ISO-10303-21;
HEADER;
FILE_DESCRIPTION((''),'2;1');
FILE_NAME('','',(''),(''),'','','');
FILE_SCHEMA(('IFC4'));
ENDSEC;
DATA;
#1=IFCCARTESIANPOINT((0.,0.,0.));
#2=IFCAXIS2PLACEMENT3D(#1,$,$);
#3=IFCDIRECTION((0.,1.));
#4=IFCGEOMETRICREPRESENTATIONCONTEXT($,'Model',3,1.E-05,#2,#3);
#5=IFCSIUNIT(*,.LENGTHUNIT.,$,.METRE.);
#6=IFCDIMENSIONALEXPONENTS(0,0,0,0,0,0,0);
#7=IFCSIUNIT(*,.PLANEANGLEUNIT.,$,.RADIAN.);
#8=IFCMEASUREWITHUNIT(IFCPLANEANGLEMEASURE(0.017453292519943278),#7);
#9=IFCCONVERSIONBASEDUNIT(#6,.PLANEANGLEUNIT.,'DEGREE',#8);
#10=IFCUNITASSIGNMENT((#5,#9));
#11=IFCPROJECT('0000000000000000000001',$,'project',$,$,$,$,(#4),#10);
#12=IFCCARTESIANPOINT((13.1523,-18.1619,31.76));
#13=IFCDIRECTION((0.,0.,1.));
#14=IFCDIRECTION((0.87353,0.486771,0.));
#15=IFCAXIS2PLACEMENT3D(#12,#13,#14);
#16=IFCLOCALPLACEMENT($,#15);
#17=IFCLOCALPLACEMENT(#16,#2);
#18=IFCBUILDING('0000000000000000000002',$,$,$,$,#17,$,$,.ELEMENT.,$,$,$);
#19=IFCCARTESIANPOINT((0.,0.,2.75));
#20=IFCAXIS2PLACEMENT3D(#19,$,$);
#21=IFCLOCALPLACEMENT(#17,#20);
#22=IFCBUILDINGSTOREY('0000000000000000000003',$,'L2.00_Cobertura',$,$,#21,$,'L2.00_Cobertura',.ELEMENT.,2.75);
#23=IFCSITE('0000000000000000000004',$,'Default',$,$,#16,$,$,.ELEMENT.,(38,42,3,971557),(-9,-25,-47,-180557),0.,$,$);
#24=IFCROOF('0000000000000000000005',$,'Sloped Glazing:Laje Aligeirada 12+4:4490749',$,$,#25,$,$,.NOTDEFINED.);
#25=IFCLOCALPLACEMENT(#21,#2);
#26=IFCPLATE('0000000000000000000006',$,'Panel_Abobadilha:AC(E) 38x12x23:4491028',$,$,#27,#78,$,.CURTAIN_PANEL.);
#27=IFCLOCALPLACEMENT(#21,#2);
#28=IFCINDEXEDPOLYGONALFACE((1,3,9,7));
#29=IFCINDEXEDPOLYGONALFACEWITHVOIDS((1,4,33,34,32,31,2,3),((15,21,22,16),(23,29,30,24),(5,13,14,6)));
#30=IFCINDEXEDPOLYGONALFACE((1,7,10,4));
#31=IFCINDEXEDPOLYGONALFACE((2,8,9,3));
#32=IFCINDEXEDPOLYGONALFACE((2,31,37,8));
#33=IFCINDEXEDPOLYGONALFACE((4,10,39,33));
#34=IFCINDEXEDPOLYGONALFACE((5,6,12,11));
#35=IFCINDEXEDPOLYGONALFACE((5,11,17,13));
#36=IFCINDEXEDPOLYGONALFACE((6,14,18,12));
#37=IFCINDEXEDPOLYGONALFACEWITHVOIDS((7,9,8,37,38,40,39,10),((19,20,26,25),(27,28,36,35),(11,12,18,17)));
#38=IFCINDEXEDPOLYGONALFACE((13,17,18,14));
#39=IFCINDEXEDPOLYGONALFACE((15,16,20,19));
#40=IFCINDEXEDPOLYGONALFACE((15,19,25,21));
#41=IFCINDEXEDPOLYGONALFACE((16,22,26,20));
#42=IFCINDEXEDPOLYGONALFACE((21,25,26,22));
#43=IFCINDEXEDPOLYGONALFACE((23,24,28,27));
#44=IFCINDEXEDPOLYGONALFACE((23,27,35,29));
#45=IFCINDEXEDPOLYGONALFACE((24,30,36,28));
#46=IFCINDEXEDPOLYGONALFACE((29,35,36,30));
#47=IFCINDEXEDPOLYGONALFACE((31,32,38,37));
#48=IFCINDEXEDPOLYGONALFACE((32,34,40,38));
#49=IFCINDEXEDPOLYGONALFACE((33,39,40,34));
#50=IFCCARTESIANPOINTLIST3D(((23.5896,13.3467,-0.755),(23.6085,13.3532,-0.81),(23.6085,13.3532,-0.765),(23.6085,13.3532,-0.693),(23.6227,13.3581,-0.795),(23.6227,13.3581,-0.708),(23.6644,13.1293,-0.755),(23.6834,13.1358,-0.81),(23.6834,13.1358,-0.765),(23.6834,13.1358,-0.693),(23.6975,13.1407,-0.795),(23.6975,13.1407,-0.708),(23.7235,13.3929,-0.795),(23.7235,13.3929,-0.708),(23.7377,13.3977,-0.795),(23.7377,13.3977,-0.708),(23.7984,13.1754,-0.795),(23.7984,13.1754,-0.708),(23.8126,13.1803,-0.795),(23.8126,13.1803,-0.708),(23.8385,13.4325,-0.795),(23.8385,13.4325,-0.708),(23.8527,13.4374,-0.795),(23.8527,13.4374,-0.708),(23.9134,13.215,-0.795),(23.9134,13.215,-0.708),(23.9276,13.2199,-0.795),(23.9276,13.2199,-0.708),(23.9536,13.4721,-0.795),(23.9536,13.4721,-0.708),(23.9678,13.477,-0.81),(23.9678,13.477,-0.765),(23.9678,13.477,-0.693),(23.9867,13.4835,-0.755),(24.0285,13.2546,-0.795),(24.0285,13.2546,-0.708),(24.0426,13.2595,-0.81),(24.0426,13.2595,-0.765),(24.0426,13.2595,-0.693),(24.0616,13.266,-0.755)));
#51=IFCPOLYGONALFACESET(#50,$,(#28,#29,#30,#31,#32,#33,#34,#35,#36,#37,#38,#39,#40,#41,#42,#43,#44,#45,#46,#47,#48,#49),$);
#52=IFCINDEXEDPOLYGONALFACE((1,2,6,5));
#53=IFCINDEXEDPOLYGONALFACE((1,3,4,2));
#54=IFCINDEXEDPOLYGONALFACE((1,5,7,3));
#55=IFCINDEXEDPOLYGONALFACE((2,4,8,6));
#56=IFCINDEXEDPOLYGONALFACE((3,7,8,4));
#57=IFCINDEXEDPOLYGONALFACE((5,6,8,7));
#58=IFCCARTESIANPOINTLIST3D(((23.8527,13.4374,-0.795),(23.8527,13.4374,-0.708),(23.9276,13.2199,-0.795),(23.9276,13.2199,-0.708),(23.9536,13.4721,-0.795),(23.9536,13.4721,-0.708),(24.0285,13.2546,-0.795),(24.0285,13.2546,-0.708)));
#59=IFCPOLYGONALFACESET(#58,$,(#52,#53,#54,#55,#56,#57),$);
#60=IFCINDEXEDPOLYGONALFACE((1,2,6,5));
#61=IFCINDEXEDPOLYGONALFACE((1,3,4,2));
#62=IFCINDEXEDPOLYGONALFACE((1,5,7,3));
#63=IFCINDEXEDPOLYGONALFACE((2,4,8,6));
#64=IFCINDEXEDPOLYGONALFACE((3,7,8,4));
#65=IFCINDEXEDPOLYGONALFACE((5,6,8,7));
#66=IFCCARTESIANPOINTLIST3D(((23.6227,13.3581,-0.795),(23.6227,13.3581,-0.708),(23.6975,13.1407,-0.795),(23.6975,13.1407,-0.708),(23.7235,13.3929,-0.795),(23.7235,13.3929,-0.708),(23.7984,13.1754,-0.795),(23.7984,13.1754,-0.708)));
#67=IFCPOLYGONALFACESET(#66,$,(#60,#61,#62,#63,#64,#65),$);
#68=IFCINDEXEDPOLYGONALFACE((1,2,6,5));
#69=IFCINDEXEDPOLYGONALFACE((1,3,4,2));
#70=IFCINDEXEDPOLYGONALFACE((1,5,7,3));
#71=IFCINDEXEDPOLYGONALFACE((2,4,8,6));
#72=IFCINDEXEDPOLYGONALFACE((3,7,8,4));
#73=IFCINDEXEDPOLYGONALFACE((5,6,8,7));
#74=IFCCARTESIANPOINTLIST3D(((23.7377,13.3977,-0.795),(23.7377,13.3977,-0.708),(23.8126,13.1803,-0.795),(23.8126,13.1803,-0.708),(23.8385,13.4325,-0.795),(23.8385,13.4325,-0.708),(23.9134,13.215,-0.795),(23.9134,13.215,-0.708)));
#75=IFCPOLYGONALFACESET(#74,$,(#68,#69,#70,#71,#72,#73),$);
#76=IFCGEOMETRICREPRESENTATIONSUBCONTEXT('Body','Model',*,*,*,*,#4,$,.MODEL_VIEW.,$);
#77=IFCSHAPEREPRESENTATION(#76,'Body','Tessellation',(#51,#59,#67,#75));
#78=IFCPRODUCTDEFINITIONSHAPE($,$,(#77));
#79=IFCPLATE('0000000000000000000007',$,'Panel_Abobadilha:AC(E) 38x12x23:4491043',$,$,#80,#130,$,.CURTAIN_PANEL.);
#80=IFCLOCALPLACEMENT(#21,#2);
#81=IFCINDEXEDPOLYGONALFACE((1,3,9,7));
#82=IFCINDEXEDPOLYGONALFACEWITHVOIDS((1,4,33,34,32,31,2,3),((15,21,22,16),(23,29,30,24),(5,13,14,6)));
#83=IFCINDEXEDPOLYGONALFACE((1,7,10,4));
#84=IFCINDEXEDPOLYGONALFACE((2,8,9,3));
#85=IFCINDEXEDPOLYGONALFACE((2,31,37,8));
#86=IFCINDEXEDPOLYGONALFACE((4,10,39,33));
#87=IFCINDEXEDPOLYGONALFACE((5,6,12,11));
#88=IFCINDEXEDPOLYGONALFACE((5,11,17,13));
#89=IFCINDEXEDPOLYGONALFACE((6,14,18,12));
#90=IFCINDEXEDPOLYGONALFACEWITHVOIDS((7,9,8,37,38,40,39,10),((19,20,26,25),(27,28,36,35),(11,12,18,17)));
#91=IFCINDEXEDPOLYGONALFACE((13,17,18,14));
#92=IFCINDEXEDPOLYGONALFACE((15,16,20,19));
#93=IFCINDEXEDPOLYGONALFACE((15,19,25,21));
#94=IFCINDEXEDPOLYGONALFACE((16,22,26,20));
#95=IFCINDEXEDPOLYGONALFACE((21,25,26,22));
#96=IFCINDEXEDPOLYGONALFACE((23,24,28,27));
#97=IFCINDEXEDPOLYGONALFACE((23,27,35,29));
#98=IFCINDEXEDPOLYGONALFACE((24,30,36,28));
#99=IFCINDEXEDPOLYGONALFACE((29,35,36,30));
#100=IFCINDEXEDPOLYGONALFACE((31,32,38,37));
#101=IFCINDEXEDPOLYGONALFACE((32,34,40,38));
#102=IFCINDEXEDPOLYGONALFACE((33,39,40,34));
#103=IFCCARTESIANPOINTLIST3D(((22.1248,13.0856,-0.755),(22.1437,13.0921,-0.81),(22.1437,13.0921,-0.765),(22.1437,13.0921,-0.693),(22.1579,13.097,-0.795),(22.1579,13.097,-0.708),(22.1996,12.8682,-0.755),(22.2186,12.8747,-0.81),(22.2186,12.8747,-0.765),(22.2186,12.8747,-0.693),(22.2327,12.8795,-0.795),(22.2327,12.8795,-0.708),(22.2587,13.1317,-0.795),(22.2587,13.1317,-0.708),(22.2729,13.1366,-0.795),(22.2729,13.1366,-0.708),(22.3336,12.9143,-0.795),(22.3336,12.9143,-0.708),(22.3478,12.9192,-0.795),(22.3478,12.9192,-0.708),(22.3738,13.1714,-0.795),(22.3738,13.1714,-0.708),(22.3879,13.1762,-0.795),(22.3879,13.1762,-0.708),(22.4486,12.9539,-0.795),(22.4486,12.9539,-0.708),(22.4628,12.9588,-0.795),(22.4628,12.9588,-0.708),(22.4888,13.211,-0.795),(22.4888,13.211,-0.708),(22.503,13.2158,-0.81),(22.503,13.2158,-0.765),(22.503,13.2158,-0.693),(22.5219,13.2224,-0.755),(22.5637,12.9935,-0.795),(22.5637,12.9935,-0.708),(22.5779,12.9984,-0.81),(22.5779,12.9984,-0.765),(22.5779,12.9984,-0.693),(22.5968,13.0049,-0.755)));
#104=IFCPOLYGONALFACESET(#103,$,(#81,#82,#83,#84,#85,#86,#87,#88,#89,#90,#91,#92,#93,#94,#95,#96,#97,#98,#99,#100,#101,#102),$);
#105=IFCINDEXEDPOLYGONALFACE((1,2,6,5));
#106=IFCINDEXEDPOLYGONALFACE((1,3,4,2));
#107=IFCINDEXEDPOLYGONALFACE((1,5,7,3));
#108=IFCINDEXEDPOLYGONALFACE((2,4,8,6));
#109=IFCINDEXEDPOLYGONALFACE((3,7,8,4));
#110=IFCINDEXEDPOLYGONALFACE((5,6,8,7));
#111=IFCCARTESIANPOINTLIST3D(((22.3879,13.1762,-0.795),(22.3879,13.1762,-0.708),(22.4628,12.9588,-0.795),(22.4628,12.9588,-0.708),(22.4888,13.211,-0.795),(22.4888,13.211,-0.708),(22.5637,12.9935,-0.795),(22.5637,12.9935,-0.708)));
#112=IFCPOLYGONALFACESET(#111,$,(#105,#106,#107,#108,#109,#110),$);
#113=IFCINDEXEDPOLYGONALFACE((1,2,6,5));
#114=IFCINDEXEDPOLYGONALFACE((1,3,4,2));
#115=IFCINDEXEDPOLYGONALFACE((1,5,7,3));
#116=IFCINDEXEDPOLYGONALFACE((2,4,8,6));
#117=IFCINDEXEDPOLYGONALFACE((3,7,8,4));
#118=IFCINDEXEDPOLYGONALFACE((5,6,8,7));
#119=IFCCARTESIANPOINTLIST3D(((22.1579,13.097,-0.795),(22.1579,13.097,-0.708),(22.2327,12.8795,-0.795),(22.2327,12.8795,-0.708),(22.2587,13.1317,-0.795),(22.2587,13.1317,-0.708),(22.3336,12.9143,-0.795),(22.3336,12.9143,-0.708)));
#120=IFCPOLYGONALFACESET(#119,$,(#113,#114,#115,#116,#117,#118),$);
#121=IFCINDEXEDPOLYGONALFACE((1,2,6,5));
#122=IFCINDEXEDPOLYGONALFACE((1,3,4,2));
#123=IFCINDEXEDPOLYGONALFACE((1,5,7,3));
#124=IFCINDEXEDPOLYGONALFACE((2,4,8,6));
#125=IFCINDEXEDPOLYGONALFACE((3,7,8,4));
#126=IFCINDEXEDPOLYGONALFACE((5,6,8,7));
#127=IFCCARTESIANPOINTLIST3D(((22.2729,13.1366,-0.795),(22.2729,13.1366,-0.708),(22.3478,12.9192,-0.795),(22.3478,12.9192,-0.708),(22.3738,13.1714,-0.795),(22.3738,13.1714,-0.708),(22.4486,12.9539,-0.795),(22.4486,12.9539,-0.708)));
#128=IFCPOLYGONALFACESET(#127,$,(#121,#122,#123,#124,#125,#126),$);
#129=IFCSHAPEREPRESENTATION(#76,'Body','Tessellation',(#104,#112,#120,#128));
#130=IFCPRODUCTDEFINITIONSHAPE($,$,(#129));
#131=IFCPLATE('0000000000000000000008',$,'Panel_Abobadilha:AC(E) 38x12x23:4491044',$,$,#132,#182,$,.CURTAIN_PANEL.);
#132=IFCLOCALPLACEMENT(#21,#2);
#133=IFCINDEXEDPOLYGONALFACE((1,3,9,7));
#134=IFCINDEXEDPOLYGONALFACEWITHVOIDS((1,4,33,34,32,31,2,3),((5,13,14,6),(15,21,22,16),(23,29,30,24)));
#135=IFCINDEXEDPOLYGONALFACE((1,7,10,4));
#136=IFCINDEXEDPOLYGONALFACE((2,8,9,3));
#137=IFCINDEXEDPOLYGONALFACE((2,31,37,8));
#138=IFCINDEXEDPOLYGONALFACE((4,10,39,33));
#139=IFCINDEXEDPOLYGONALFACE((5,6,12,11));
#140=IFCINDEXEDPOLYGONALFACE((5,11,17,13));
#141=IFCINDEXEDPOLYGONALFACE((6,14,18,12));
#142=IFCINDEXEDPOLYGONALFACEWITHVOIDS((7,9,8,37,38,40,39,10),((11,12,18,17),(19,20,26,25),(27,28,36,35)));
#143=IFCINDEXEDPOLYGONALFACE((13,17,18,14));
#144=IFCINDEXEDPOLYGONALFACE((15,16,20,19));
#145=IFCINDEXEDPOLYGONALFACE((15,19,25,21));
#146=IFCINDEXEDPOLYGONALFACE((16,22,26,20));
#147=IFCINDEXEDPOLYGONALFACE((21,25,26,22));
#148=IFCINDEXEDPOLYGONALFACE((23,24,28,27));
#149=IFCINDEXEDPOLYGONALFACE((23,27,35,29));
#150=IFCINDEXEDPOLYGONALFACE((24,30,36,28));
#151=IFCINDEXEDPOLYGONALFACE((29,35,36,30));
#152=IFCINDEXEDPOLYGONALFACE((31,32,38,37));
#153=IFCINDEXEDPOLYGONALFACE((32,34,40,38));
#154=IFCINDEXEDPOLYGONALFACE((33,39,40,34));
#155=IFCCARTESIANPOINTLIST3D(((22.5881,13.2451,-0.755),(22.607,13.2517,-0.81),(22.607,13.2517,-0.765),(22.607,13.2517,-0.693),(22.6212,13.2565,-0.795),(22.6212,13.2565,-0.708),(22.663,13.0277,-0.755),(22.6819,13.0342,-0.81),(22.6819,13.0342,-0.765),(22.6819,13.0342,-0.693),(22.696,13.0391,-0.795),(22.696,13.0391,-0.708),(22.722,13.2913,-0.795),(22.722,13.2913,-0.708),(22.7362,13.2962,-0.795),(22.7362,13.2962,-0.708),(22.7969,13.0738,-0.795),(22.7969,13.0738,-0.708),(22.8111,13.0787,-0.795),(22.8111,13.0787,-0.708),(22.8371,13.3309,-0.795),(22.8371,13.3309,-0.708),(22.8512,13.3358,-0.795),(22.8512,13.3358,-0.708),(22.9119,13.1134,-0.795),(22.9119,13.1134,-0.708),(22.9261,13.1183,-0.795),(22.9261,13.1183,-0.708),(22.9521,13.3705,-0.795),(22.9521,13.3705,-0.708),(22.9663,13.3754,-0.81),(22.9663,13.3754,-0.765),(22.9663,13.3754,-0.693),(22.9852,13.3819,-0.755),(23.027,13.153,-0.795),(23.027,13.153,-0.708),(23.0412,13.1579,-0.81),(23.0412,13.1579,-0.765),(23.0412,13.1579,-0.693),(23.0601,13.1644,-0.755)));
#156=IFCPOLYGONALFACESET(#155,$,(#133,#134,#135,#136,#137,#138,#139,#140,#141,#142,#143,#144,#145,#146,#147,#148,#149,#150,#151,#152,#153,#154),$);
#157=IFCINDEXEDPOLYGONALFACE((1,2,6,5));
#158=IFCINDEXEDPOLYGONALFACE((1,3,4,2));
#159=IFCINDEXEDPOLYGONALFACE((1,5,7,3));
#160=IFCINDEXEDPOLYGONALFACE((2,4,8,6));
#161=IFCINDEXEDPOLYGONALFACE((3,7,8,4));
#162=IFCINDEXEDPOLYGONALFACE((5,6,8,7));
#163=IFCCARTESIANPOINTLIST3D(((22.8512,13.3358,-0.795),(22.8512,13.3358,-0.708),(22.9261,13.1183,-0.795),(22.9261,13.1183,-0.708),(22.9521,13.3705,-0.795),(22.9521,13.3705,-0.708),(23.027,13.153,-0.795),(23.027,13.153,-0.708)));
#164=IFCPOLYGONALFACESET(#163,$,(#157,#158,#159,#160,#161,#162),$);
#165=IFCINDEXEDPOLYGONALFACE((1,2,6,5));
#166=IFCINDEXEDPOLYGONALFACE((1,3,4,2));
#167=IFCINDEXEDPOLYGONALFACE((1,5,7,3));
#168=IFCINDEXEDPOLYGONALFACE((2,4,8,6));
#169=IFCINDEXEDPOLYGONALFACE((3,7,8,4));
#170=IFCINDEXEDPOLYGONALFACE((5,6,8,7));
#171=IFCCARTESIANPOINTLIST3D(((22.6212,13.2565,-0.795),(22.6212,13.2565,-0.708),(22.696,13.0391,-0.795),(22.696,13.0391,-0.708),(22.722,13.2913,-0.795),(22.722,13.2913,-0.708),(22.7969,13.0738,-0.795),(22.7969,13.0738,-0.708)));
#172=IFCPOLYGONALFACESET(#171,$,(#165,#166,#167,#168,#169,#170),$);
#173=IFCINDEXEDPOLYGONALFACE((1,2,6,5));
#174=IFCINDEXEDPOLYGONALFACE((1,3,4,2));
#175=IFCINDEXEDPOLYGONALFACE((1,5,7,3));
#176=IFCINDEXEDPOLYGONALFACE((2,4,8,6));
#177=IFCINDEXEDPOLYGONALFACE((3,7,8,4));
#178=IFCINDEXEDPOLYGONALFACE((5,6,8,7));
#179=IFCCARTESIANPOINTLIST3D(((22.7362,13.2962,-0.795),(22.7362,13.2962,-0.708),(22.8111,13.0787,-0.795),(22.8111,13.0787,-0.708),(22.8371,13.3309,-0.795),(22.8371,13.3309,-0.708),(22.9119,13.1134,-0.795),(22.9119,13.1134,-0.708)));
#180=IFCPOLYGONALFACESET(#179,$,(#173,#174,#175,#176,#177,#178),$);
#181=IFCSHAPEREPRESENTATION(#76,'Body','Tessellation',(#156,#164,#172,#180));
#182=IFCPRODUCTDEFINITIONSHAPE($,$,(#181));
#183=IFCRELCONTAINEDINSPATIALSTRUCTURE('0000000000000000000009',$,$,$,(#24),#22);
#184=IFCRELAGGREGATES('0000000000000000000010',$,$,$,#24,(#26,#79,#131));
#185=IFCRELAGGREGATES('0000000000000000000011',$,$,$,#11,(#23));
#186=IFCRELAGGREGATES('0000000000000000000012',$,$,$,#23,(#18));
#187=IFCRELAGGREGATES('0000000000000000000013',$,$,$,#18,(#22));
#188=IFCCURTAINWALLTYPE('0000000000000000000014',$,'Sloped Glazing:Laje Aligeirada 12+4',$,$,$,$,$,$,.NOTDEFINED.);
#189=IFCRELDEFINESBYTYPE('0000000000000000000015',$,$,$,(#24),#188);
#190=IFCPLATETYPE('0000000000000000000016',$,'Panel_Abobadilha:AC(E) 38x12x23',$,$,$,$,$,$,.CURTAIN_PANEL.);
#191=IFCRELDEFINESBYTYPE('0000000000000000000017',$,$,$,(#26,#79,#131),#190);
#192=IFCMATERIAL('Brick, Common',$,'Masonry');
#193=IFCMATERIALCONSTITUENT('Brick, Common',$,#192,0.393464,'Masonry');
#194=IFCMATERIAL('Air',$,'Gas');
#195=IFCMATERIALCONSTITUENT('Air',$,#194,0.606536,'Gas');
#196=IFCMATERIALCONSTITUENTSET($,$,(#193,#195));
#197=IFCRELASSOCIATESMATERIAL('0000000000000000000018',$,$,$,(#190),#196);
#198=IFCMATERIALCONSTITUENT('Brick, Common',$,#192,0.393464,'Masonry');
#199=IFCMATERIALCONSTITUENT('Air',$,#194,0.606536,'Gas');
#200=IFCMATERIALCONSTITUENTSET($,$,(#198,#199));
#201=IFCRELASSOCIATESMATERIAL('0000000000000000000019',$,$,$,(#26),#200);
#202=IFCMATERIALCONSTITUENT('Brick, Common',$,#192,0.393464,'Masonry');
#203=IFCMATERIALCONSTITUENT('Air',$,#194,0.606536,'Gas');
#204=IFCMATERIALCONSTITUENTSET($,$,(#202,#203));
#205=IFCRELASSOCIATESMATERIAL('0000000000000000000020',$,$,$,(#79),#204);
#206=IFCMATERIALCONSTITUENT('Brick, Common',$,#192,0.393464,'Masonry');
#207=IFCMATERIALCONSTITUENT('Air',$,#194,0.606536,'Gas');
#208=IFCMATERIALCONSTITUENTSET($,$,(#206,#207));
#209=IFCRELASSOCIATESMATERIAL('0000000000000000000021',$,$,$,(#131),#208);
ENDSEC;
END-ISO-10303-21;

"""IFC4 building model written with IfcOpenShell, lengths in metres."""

from ifc_helpers import new_model, entity, si_unit, converted_unit, direction, frame, origin, place, context, subcontext, project, spatial, indexed_curve, outline, extrude, source, transform, mapped, material, constituent, constituent_set, type_object, type_shapes, element, aggregate, save


model = new_model("IFC4")

# Units and contexts
model_context = context("Model", 3, precision=1e-05, world=origin(), true_north=direction((0.0, 1.0)))
body_context = subcontext(model_context, "Body", "Model", "MODEL_VIEW")
ifc_project = project(units=[si_unit("LENGTHUNIT", "METRE"), converted_unit("PLANEANGLEUNIT", "DEGREE", entity("IfcPlaneAngleMeasure", 0.017453292519943278), si_unit("PLANEANGLEUNIT", "RADIAN"), dimensions=[0, 0, 0, 0, 0, 0, 0])], contexts=[model_context])

# Site, building, storey
site_placement = place(None, frame((13.1523, -18.1619, 31.76), z_axis=(0.0, 0.0, 1.0), x_axis=(0.87353, 0.486771, 0.0)))
site = spatial("IfcSite", under=ifc_project, at=site_placement, Name="Default", CompositionType="ELEMENT", RefLatitude=(38, 42, 3, 971557), RefLongitude=(-9, -25, -47, -180557), RefElevation=0.0)
building_placement = place(site_placement, origin())
building = spatial("IfcBuilding", under=site, at=building_placement, CompositionType="ELEMENT")
storey_placement = place(building_placement, frame((0.0, 0.0, 2.75)))
storey = spatial("IfcBuildingStorey", under=building, at=storey_placement, Name="L2.00_Cobertura", LongName="L2.00_Cobertura", CompositionType="ELEMENT", Elevation=2.75)

# Roof, plates
curtain_wall_type = type_object("IfcCurtainWallType", Name="Sloped Glazing:Laje Aligeirada 12+4", PredefinedType="NOTDEFINED")
roof_placement = place(storey_placement, frame((0.0, 0.0, -2.75)))
roof = element("IfcRoof", 1, at=roof_placement, inside=storey, type_object=curtain_wall_type, Name="Sloped Glazing:Laje Aligeirada 12+4:4490749", PredefinedType="NOTDEFINED")
ifc_material_1 = material(Name="Brick, Common", Category="Masonry")
ifc_material_2 = material(Name="Air", Category="Gas")
ifc_constituent_1 = constituent(ifc_material_1, Name="Brick, Common", Category="Masonry", fraction=0.393464)
ifc_constituent_2 = constituent(ifc_material_2, Name="Air", Category="Gas", fraction=0.606536)
ifc_constituent_set_1 = constituent_set(constituents=[ifc_constituent_1, ifc_constituent_2])
plate_type = type_object("IfcPlateType", Name="Panel_Abobadilha:AC(E) 38x12x23", PredefinedType="CURTAIN_PANEL", material=ifc_constituent_set_1)
shared_shape_1 = source(origin(), body_context, "Body", "SweptSolid", [
    extrude(outline(indexed_curve([(-0.19, -0.0543), (0.19, -0.0543), (0.19, -0.0093), (0.21, 0.0007), (0.19, 0.0628), (-0.19, 0.0628), (-0.21, 0.0007), (-0.19, -0.0093), (-0.19, -0.0543)], self_intersect=False), holes=[indexed_curve([(-0.0683, 0.0477), (-0.0683, -0.0393), (-0.175, -0.0393), (-0.175, 0.0477), (-0.0683, 0.0477)], self_intersect=False), indexed_curve([(0.0533, 0.0477), (0.0533, -0.0393), (-0.0533, -0.0393), (-0.0533, 0.0477), (0.0533, 0.0477)], self_intersect=False), indexed_curve([(0.175, 0.0477), (0.175, -0.0393), (0.0683, -0.0393), (0.0683, 0.0477), (0.175, 0.0477)], self_intersect=False)]), frame((0.0, 0.0543, 0.0)), (0.0, 0.0, 1.0), 0.23),
    extrude(outline(indexed_curve([(-0.0533, -0.0435), (0.0533, -0.0435), (0.0533, 0.0435), (-0.0533, 0.0435), (-0.0533, -0.0435)], self_intersect=False)), frame((0.1217, 0.0585, 0.0), z_axis=(0.0, 0.0, 1.0), x_axis=(-1.0, 0.0, 0.0)), (0.0, 0.0, 1.0), 0.23),
    extrude(outline(indexed_curve([(-0.0533, -0.0435), (0.0533, -0.0435), (0.0533, 0.0435), (-0.0533, 0.0435), (-0.0533, -0.0435)], self_intersect=False)), frame((-0.1217, 0.0585, 0.0), z_axis=(0.0, 0.0, 1.0), x_axis=(-1.0, 0.0, 0.0)), (0.0, 0.0, 1.0), 0.23),
    extrude(outline(indexed_curve([(-0.0533, -0.0435), (0.0533, -0.0435), (0.0533, 0.0435), (-0.0533, 0.0435), (-0.0533, -0.0435)], self_intersect=False)), frame((0.0, 0.0585, 0.0), z_axis=(0.0, 0.0, 1.0), x_axis=(-1.0, 0.0, 0.0)), (0.0, 0.0, 1.0), 0.23),
])
type_shapes(plate_type, [shared_shape_1])
ifc_constituent_3 = constituent(ifc_material_1, Name="Brick, Common", Category="Masonry", fraction=0.393464)
ifc_constituent_4 = constituent(ifc_material_2, Name="Air", Category="Gas", fraction=0.606536)
ifc_constituent_set_2 = constituent_set(constituents=[ifc_constituent_3, ifc_constituent_4])
plate_1_placement = place(roof_placement, frame((23.7881, 13.4151, 1.94), z_axis=(0.325568, -0.945519, 0.0), x_axis=(0.945519, 0.325568, 0.0)))
plate_1 = element("IfcPlate", 2, at=plate_1_placement, type_object=plate_type, material=ifc_constituent_set_2, Name="Panel_Abobadilha:AC(E) 38x12x23:4491028", PredefinedType="CURTAIN_PANEL", context=body_context, shape_type="MappedRepresentation", body=[
    mapped(shared_shape_1, transform((0.0, 0.0, 0.0), scale=1.0)),
])
ifc_constituent_5 = constituent(ifc_material_1, Name="Brick, Common", Category="Masonry", fraction=0.393464)
ifc_constituent_6 = constituent(ifc_material_2, Name="Air", Category="Gas", fraction=0.606536)
ifc_constituent_set_3 = constituent_set(constituents=[ifc_constituent_5, ifc_constituent_6])
plate_2_placement = place(roof_placement, frame((22.3233, 13.154, 1.94), z_axis=(0.325568, -0.945519, 0.0), x_axis=(0.945519, 0.325568, 0.0)))
plate_2 = element("IfcPlate", 3, at=plate_2_placement, type_object=plate_type, material=ifc_constituent_set_3, Name="Panel_Abobadilha:AC(E) 38x12x23:4491043", PredefinedType="CURTAIN_PANEL", context=body_context, shape_type="MappedRepresentation", body=[
    mapped(shared_shape_1, transform((0.0, 0.0, 0.0), scale=1.0)),
])
ifc_constituent_7 = constituent(ifc_material_1, Name="Brick, Common", Category="Masonry", fraction=0.393464)
ifc_constituent_8 = constituent(ifc_material_2, Name="Air", Category="Gas", fraction=0.606536)
ifc_constituent_set_4 = constituent_set(constituents=[ifc_constituent_7, ifc_constituent_8])
plate_3_placement = place(roof_placement, frame((22.7866, 13.3135, 1.94), z_axis=(0.325568, -0.945519, 0.0), x_axis=(0.945519, 0.325568, 0.0)))
plate_3 = element("IfcPlate", 4, at=plate_3_placement, type_object=plate_type, material=ifc_constituent_set_4, Name="Panel_Abobadilha:AC(E) 38x12x23:4491044", PredefinedType="CURTAIN_PANEL", context=body_context, shape_type="MappedRepresentation", body=[
    mapped(shared_shape_1, transform((0.0, 0.0, 0.0), scale=1.0)),
])
aggregate(roof, [plate_1, plate_2, plate_3])

save(model, "model.ifc")
